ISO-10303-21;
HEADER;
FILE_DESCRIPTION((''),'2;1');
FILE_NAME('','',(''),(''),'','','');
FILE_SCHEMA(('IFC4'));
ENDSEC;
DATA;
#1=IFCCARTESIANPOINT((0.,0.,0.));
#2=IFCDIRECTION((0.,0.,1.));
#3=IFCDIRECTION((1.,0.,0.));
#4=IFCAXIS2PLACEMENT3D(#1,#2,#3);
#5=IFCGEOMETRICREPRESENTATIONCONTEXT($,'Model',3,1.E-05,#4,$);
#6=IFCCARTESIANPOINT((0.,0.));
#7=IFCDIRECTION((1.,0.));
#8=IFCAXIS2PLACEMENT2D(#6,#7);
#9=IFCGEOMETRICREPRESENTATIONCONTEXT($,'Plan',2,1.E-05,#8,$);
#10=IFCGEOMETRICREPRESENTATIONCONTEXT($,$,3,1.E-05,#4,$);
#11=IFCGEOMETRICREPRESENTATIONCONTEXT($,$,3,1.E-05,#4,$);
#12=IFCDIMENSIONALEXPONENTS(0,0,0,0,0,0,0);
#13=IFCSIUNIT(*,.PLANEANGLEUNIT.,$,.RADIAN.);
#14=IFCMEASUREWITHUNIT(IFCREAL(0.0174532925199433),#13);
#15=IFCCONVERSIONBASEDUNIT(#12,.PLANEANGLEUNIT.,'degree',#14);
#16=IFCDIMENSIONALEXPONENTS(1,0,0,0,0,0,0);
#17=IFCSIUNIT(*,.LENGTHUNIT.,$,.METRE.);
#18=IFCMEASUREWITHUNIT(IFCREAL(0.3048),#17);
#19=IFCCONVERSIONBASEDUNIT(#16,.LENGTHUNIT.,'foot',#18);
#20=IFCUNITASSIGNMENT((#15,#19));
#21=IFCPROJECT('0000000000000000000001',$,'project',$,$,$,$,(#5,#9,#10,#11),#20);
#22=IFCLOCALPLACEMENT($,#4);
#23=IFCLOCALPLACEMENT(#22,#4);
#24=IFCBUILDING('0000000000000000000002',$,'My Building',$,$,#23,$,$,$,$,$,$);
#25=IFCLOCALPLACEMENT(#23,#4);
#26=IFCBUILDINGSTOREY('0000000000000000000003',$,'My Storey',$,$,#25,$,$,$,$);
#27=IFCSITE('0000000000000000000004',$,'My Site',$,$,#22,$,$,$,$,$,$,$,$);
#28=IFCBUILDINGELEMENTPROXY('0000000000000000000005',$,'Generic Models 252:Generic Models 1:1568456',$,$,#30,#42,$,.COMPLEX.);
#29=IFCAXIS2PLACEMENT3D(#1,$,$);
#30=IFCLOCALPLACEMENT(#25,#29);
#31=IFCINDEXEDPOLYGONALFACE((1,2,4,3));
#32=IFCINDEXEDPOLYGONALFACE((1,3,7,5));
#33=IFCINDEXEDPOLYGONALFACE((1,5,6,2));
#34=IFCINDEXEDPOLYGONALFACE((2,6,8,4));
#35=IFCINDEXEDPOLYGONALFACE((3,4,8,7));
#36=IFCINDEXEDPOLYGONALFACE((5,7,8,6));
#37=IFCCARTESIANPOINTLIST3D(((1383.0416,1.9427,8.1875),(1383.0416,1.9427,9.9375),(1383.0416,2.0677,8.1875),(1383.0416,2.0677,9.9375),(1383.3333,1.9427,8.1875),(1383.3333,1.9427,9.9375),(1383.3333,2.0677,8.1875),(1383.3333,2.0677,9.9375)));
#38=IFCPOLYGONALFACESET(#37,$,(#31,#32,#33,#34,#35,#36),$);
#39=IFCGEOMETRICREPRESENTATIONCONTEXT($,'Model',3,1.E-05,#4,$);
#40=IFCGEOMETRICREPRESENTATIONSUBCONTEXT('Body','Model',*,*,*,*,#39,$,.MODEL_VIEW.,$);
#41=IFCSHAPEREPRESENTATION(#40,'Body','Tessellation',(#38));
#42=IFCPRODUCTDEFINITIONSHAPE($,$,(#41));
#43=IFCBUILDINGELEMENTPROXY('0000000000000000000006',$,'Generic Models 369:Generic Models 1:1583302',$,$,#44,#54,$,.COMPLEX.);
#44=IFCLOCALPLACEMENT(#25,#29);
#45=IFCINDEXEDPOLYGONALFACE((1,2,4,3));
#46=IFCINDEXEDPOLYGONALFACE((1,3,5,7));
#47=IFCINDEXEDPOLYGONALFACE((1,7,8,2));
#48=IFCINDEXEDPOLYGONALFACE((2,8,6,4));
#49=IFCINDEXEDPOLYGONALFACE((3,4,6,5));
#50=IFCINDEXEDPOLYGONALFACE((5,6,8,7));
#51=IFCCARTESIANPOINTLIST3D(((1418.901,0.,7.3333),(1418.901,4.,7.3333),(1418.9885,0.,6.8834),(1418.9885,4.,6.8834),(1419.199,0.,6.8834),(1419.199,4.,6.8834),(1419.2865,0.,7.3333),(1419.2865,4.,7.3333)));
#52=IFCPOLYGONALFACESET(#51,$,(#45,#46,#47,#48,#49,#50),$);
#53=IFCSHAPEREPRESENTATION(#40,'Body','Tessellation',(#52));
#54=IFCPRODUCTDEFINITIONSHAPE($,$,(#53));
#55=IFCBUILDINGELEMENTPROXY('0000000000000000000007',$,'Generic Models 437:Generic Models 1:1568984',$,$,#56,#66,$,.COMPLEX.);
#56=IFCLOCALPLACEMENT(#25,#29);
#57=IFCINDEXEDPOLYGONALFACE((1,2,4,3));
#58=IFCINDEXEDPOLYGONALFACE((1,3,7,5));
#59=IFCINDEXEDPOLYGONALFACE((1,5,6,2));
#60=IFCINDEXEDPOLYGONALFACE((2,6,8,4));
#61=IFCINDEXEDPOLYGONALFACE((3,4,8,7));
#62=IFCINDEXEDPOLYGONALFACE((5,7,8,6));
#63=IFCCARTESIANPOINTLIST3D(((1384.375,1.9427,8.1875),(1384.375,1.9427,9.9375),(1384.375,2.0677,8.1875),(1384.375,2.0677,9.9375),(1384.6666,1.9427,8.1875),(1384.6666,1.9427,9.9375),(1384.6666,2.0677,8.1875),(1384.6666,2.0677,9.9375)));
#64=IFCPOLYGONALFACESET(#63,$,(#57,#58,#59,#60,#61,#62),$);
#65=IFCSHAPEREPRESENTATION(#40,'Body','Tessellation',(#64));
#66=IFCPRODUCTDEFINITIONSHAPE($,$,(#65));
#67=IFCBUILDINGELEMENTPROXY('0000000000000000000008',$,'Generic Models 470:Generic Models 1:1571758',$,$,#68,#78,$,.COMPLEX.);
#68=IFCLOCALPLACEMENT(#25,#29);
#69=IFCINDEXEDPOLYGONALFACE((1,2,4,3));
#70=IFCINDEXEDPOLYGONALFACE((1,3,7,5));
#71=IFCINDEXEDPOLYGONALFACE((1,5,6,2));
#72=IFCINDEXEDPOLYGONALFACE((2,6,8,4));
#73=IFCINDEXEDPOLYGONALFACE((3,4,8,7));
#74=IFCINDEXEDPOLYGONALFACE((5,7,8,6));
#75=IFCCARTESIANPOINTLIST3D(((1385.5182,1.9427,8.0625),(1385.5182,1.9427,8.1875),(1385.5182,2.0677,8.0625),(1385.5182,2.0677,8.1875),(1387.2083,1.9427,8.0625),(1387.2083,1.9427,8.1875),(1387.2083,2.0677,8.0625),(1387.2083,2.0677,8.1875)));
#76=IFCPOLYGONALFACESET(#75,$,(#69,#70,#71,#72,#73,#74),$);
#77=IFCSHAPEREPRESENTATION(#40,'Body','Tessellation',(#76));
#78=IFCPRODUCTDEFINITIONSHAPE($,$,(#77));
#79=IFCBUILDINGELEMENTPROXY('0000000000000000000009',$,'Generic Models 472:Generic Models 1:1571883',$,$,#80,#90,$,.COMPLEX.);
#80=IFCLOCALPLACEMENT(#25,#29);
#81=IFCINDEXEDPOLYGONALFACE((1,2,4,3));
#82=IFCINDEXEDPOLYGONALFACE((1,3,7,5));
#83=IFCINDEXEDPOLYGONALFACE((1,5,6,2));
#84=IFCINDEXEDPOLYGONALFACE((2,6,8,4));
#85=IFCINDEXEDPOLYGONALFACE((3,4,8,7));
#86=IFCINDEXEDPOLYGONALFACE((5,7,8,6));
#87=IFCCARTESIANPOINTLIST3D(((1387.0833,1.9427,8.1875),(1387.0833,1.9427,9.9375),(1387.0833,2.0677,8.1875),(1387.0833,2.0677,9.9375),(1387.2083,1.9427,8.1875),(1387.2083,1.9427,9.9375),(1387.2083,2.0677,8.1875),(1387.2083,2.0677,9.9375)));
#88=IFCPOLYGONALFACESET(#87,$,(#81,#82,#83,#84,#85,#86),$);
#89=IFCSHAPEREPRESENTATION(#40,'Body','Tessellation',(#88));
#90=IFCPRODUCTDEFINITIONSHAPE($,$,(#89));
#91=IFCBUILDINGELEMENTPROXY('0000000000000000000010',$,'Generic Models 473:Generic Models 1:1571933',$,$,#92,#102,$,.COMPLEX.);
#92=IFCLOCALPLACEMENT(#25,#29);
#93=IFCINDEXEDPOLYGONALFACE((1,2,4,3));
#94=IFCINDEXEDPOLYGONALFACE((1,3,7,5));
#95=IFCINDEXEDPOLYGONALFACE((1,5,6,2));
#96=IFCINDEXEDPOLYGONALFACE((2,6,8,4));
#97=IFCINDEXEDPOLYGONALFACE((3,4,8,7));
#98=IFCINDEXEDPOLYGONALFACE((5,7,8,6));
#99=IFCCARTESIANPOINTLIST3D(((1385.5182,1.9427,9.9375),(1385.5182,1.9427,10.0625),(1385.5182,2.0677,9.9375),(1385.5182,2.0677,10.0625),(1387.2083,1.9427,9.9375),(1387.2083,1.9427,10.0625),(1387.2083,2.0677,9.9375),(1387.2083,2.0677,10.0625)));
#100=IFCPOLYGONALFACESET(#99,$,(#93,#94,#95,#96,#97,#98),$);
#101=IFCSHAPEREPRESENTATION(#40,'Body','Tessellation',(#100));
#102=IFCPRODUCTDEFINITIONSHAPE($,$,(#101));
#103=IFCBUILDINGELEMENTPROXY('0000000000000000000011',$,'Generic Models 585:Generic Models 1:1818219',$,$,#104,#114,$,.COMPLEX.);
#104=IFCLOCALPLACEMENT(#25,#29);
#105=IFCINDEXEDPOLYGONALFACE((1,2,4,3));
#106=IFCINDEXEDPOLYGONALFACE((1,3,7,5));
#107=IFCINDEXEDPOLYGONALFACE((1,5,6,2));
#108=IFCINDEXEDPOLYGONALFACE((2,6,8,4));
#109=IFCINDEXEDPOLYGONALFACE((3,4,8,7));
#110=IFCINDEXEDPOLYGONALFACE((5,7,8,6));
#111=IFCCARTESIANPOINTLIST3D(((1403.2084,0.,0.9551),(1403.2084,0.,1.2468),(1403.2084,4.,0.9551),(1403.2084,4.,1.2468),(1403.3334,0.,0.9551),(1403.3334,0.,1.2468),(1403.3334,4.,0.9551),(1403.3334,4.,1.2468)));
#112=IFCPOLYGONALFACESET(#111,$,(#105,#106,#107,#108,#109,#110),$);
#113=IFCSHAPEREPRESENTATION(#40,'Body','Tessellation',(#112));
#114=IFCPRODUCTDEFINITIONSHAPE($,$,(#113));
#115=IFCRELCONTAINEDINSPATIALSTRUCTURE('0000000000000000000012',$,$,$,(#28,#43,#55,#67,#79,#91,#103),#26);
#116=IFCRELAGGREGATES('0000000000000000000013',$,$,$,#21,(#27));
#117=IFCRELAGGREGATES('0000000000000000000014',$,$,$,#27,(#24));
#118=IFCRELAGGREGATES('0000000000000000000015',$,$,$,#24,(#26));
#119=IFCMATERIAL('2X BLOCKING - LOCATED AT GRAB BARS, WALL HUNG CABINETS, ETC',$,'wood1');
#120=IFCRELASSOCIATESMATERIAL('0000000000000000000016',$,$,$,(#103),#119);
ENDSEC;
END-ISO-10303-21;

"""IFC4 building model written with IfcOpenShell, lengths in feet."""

from ifc_helpers import new_model, entity, si_unit, converted_unit, frame, origin_with_axes, origin_2d_with_axis, place, context, subcontext, project, spatial, polyline, line, indexed_curve, outline, extrude, material, element, save


model = new_model("IFC4")

# Units and contexts
model_context_1 = context("Model", 3, precision=1e-05, world=origin_with_axes())
plan_context = context("Plan", 2, precision=1e-05, world=origin_2d_with_axis())
model_context_2 = context("Model", 3, precision=1e-05, world=origin_with_axes())
context_of_model_1 = context(None, 3, precision=1e-05, world=origin_with_axes())
context_of_model_2 = context(None, 3, precision=1e-05, world=origin_with_axes())
body_context_1 = subcontext(model_context_2, "Body", "Model", "MODEL_VIEW")
ifc_project = project(units=[converted_unit("PLANEANGLEUNIT", "degree", entity("IfcReal", 0.0174532925199433), si_unit("PLANEANGLEUNIT", "RADIAN"), dimensions=[0, 0, 0, 0, 0, 0, 0]), converted_unit("LENGTHUNIT", "foot", entity("IfcReal", 0.3048), si_unit("LENGTHUNIT", "METRE"), dimensions=[1, 0, 0, 0, 0, 0, 0])], contexts=[model_context_1, plan_context, context_of_model_1, context_of_model_2])

# Site, building, storey
site_placement = place(None, origin_with_axes())
site = spatial("IfcSite", under=ifc_project, at=site_placement, Name="My Site")
building_placement = place(site_placement, origin_with_axes())
building = spatial("IfcBuilding", under=site, at=building_placement, Name="My Building")
storey_placement = place(building_placement, origin_with_axes())
storey = spatial("IfcBuildingStorey", under=building, at=storey_placement, Name="My Storey")

# Building element proxies
proxy_1_placement = place(storey_placement, frame((1383.0416, 1.9427, 8.1875), z_axis=(0.0, 0.0, 1.0), x_axis=(1.0, 0.0, 0.0)))
element("IfcBuildingElementProxy", 1, at=proxy_1_placement, inside=storey, Name="Generic Models 252:Generic Models 1:1568456", PredefinedType="COMPLEX", context=body_context_1, shape_type="SweptSolid", body=[
    extrude(outline(polyline([(-0.1458, -0.0625), (0.1458, -0.0625), (0.1458, 0.0625), (-0.1458, 0.0625), (-0.1458, -0.0625)])), frame((0.1458, 0.0625, 0.0), z_axis=(0.0, 0.0, -1.0), x_axis=(-1.0, 0.0, 0.0)), (0.0, 0.0, -1.0), 1.75),
])
proxy_2_placement = place(storey_placement, frame((1419.2865, 0.0, 6.8834), z_axis=(0.0, 1.0, 0.0), x_axis=(0.0, 0.0, 1.0)))
element("IfcBuildingElementProxy", 2, at=proxy_2_placement, inside=storey, Name="Generic Models 369:Generic Models 1:1583302", PredefinedType="COMPLEX", context=body_context_1, shape_type="SweptSolid", body=[
    extrude(outline(indexed_curve([(-0.1053, 0.225), (0.1053, 0.225), (0.1927, -0.225), (-0.1927, -0.225)], segments=[line(4, 1), line(1, 2), line(2, 3), line(3, 4)], self_intersect=False)), frame((0.225, -0.1927, 4.0), z_axis=(0.0, 0.0, -1.0), x_axis=(0.0, -1.0, 0.0)), (0.0, 0.0, 1.0), 4.0),
])
proxy_3_placement = place(storey_placement, frame((1384.375, 1.9427, 8.1875), z_axis=(0.0, 0.0, 1.0), x_axis=(1.0, 0.0, 0.0)))
element("IfcBuildingElementProxy", 3, at=proxy_3_placement, inside=storey, Name="Generic Models 437:Generic Models 1:1568984", PredefinedType="COMPLEX", context=body_context_1, shape_type="SweptSolid", body=[
    extrude(outline(polyline([(-0.1458, -0.0625), (0.1458, -0.0625), (0.1458, 0.0625), (-0.1458, 0.0625), (-0.1458, -0.0625)])), frame((0.1458, 0.0625, 0.0), z_axis=(0.0, 0.0, -1.0), x_axis=(-1.0, 0.0, 0.0)), (0.0, 0.0, -1.0), 1.75),
])
proxy_4_placement = place(storey_placement, frame((1385.5182, 1.9427, 8.0625), z_axis=(1.0, 0.0, 0.0), x_axis=(0.0, 0.0, -1.0)))
element("IfcBuildingElementProxy", 4, at=proxy_4_placement, inside=storey, Name="Generic Models 470:Generic Models 1:1571758", PredefinedType="COMPLEX", context=body_context_1, shape_type="SweptSolid", body=[
    extrude(outline(polyline([(-0.0625, -0.0625), (0.0625, -0.0625), (0.0625, 0.0625), (-0.0625, 0.0625), (-0.0625, -0.0625)])), frame((-0.0625, 0.0625, 0.0), z_axis=(0.0, 0.0, -1.0), x_axis=(1.0, 0.0, 0.0)), (0.0, 0.0, -1.0), 1.6902),
])
proxy_5_placement = place(storey_placement, frame((1387.0833, 1.9427, 8.1875), z_axis=(0.0, 0.0, 1.0), x_axis=(0.0, 1.0, 0.0)))
element("IfcBuildingElementProxy", 5, at=proxy_5_placement, inside=storey, Name="Generic Models 472:Generic Models 1:1571883", PredefinedType="COMPLEX", context=body_context_1, shape_type="SweptSolid", body=[
    extrude(outline(polyline([(-0.0625, -0.0625), (0.0625, -0.0625), (0.0625, 0.0625), (-0.0625, 0.0625), (-0.0625, -0.0625)])), frame((0.0625, -0.0625, 0.0), z_axis=(0.0, 0.0, -1.0), x_axis=(-1.0, 0.0, 0.0)), (0.0, 0.0, -1.0), 1.75),
])
proxy_6_placement = place(storey_placement, frame((1385.5182, 1.9427, 9.9375), z_axis=(1.0, 0.0, 0.0), x_axis=(0.0, 0.0, -1.0)))
element("IfcBuildingElementProxy", 6, at=proxy_6_placement, inside=storey, Name="Generic Models 473:Generic Models 1:1571933", PredefinedType="COMPLEX", context=body_context_1, shape_type="SweptSolid", body=[
    extrude(outline(polyline([(-0.0625, -0.0625), (0.0625, -0.0625), (0.0625, 0.0625), (-0.0625, 0.0625), (-0.0625, -0.0625)])), frame((-0.0625, 0.0625, 0.0), z_axis=(0.0, 0.0, -1.0), x_axis=(1.0, 0.0, 0.0)), (0.0, 0.0, -1.0), 1.6902),
])
ifc_material_1 = material(Name="2X BLOCKING - LOCATED AT GRAB BARS, WALL HUNG CABINETS, ETC", Category="wood1")
proxy_7_placement = place(storey_placement, frame((1403.2084, 0.0, 0.9551), z_axis=(0.0, 0.0, 1.0), x_axis=(0.0, 1.0, 0.0)))
element("IfcBuildingElementProxy", 7, at=proxy_7_placement, inside=storey, material=ifc_material_1, Name="Generic Models 585:Generic Models 1:1818219", PredefinedType="COMPLEX", context=body_context_1, shape_type="SweptSolid", body=[
    extrude(outline(polyline([(-2.0, -0.0625), (2.0, -0.0625), (2.0, 0.0625), (-2.0, 0.0625), (-2.0, -0.0625)])), frame((2.0, -0.0625, 0.0), z_axis=(0.0, 0.0, -1.0), x_axis=(1.0, 0.0, 0.0)), (0.0, 0.0, -1.0), 0.2917),
])

save(model, "model.ifc")
